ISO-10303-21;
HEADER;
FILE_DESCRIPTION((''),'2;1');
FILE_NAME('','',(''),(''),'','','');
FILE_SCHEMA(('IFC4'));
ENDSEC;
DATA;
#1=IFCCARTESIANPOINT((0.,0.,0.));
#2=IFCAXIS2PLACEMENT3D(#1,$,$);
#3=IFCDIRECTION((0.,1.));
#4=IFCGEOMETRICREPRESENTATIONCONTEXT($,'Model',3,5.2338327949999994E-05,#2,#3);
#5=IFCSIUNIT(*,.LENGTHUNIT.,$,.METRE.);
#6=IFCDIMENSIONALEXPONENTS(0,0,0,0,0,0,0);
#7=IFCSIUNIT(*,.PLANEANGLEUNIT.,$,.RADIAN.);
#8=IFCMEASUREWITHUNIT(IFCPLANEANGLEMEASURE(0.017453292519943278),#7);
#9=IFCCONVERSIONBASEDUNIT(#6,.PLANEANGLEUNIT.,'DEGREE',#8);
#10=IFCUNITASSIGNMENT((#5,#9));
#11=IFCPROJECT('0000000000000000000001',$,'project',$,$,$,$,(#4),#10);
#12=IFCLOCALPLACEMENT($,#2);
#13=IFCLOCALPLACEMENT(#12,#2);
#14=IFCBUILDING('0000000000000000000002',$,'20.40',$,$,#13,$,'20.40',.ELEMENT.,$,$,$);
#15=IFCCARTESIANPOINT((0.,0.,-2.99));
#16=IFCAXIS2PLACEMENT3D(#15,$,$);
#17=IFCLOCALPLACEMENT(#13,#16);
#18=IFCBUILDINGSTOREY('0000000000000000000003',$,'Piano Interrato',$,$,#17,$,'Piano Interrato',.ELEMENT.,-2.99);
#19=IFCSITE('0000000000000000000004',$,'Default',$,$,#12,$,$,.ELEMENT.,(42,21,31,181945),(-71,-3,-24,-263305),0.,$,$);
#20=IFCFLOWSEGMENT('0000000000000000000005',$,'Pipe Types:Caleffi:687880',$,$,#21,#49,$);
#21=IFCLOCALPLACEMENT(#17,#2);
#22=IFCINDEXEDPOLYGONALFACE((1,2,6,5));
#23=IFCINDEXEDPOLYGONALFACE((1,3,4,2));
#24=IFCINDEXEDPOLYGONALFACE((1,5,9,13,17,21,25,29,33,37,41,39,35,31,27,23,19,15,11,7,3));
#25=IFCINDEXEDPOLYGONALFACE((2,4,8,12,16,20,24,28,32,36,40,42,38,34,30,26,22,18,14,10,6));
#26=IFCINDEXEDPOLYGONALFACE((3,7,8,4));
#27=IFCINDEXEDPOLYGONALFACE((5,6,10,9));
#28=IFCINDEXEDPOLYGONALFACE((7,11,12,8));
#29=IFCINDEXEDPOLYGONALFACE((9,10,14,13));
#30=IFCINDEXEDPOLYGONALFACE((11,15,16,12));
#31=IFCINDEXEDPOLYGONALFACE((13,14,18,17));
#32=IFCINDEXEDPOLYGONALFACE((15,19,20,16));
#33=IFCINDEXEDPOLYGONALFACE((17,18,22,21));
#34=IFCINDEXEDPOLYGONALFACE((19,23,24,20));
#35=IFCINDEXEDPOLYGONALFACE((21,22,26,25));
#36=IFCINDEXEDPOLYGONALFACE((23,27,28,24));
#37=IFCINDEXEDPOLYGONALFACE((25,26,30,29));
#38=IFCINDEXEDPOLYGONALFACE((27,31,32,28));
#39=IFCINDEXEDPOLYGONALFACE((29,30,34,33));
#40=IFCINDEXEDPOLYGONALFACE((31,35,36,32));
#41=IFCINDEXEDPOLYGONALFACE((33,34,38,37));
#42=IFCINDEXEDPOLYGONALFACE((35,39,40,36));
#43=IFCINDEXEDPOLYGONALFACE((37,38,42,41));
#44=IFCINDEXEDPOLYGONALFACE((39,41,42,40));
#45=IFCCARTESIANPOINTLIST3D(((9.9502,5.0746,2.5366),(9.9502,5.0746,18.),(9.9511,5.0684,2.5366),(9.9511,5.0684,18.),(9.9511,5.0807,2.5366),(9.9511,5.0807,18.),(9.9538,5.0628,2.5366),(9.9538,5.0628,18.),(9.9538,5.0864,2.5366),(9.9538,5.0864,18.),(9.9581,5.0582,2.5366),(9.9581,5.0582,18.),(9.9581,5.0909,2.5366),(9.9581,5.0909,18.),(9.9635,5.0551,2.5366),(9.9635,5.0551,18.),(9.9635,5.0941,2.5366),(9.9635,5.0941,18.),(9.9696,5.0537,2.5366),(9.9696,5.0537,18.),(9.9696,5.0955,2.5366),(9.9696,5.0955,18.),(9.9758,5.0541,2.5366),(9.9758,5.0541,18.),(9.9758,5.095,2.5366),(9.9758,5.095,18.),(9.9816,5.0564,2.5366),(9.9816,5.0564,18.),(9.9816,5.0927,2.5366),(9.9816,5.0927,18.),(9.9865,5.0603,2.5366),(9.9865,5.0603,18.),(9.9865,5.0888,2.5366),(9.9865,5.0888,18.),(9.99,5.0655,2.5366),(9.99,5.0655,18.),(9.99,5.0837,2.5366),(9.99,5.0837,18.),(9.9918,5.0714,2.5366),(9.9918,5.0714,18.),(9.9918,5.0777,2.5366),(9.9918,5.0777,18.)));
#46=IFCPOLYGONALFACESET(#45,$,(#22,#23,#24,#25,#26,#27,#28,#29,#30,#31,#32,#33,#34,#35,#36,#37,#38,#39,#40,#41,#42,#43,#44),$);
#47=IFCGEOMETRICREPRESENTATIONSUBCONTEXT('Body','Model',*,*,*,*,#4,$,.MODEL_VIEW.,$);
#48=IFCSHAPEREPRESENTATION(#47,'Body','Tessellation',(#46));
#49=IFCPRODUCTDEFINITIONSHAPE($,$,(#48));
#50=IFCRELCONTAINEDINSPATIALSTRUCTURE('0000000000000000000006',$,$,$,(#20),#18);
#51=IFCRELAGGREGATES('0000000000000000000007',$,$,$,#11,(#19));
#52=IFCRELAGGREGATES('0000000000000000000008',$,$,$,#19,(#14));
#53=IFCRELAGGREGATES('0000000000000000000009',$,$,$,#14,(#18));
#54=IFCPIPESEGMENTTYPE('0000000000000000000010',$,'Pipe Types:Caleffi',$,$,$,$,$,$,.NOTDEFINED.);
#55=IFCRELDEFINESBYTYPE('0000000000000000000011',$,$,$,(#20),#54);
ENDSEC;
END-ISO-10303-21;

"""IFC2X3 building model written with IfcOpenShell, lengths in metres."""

from ifc_helpers import new_model, entity, si_unit, converted_unit, direction, frame, origin, origin_2d_with_axis, place, context, subcontext, project, spatial, circle, extrude, type_object, element, save


model = new_model("IFC2X3")

# Units and contexts
model_context = context("Model", 3, precision=5.2338327949999994e-05, world=origin(), true_north=direction((0.0, 1.0)))
body_context = subcontext(model_context, "Body", "Model", "MODEL_VIEW")
ifc_project = project(units=[si_unit("LENGTHUNIT", "METRE"), converted_unit("PLANEANGLEUNIT", "DEGREE", entity("IfcPlaneAngleMeasure", 0.017453292519943278), si_unit("PLANEANGLEUNIT", "RADIAN"), dimensions=[0, 0, 0, 0, 0, 0, 0])], contexts=[model_context])

# Site, building, storey
site_placement = place(None, origin())
site = spatial("IfcSite", under=ifc_project, at=site_placement, Name="Default", CompositionType="ELEMENT", RefLatitude=(42, 21, 31, 181945), RefLongitude=(-71, -3, -24, -263305), RefElevation=0.0)
building_placement = place(site_placement, origin())
building = spatial("IfcBuilding", under=site, at=building_placement, Name="20.40", LongName="20.40", CompositionType="ELEMENT")
storey_placement = place(building_placement, frame((0.0, 0.0, -2.99)))
storey = spatial("IfcBuildingStorey", under=building, at=storey_placement, Name="Piano Interrato", LongName="Piano Interrato", CompositionType="ELEMENT", Elevation=-2.99)

# Flow segment
pipe_segment_type = type_object("IfcPipeSegmentType", Name="Pipe Types:Caleffi", PredefinedType="NOTDEFINED")
flow_segment_1_placement = place(storey_placement, origin())
element("IfcFlowSegment", 1, at=flow_segment_1_placement, inside=storey, type_object=pipe_segment_type, Name="Pipe Types:Caleffi:687880", context=body_context, shape_type="SweptSolid", body=[
    extrude(circle(Radius=0.0209, at=origin_2d_with_axis()), frame((9.9711, 5.0746, 2.5366), z_axis=(0.0, 0.0, 1.0), x_axis=(-1.0, 0.0, 0.0)), (0.0, 0.0, 1.0), 15.4634),
])

save(model, "model.ifc")
